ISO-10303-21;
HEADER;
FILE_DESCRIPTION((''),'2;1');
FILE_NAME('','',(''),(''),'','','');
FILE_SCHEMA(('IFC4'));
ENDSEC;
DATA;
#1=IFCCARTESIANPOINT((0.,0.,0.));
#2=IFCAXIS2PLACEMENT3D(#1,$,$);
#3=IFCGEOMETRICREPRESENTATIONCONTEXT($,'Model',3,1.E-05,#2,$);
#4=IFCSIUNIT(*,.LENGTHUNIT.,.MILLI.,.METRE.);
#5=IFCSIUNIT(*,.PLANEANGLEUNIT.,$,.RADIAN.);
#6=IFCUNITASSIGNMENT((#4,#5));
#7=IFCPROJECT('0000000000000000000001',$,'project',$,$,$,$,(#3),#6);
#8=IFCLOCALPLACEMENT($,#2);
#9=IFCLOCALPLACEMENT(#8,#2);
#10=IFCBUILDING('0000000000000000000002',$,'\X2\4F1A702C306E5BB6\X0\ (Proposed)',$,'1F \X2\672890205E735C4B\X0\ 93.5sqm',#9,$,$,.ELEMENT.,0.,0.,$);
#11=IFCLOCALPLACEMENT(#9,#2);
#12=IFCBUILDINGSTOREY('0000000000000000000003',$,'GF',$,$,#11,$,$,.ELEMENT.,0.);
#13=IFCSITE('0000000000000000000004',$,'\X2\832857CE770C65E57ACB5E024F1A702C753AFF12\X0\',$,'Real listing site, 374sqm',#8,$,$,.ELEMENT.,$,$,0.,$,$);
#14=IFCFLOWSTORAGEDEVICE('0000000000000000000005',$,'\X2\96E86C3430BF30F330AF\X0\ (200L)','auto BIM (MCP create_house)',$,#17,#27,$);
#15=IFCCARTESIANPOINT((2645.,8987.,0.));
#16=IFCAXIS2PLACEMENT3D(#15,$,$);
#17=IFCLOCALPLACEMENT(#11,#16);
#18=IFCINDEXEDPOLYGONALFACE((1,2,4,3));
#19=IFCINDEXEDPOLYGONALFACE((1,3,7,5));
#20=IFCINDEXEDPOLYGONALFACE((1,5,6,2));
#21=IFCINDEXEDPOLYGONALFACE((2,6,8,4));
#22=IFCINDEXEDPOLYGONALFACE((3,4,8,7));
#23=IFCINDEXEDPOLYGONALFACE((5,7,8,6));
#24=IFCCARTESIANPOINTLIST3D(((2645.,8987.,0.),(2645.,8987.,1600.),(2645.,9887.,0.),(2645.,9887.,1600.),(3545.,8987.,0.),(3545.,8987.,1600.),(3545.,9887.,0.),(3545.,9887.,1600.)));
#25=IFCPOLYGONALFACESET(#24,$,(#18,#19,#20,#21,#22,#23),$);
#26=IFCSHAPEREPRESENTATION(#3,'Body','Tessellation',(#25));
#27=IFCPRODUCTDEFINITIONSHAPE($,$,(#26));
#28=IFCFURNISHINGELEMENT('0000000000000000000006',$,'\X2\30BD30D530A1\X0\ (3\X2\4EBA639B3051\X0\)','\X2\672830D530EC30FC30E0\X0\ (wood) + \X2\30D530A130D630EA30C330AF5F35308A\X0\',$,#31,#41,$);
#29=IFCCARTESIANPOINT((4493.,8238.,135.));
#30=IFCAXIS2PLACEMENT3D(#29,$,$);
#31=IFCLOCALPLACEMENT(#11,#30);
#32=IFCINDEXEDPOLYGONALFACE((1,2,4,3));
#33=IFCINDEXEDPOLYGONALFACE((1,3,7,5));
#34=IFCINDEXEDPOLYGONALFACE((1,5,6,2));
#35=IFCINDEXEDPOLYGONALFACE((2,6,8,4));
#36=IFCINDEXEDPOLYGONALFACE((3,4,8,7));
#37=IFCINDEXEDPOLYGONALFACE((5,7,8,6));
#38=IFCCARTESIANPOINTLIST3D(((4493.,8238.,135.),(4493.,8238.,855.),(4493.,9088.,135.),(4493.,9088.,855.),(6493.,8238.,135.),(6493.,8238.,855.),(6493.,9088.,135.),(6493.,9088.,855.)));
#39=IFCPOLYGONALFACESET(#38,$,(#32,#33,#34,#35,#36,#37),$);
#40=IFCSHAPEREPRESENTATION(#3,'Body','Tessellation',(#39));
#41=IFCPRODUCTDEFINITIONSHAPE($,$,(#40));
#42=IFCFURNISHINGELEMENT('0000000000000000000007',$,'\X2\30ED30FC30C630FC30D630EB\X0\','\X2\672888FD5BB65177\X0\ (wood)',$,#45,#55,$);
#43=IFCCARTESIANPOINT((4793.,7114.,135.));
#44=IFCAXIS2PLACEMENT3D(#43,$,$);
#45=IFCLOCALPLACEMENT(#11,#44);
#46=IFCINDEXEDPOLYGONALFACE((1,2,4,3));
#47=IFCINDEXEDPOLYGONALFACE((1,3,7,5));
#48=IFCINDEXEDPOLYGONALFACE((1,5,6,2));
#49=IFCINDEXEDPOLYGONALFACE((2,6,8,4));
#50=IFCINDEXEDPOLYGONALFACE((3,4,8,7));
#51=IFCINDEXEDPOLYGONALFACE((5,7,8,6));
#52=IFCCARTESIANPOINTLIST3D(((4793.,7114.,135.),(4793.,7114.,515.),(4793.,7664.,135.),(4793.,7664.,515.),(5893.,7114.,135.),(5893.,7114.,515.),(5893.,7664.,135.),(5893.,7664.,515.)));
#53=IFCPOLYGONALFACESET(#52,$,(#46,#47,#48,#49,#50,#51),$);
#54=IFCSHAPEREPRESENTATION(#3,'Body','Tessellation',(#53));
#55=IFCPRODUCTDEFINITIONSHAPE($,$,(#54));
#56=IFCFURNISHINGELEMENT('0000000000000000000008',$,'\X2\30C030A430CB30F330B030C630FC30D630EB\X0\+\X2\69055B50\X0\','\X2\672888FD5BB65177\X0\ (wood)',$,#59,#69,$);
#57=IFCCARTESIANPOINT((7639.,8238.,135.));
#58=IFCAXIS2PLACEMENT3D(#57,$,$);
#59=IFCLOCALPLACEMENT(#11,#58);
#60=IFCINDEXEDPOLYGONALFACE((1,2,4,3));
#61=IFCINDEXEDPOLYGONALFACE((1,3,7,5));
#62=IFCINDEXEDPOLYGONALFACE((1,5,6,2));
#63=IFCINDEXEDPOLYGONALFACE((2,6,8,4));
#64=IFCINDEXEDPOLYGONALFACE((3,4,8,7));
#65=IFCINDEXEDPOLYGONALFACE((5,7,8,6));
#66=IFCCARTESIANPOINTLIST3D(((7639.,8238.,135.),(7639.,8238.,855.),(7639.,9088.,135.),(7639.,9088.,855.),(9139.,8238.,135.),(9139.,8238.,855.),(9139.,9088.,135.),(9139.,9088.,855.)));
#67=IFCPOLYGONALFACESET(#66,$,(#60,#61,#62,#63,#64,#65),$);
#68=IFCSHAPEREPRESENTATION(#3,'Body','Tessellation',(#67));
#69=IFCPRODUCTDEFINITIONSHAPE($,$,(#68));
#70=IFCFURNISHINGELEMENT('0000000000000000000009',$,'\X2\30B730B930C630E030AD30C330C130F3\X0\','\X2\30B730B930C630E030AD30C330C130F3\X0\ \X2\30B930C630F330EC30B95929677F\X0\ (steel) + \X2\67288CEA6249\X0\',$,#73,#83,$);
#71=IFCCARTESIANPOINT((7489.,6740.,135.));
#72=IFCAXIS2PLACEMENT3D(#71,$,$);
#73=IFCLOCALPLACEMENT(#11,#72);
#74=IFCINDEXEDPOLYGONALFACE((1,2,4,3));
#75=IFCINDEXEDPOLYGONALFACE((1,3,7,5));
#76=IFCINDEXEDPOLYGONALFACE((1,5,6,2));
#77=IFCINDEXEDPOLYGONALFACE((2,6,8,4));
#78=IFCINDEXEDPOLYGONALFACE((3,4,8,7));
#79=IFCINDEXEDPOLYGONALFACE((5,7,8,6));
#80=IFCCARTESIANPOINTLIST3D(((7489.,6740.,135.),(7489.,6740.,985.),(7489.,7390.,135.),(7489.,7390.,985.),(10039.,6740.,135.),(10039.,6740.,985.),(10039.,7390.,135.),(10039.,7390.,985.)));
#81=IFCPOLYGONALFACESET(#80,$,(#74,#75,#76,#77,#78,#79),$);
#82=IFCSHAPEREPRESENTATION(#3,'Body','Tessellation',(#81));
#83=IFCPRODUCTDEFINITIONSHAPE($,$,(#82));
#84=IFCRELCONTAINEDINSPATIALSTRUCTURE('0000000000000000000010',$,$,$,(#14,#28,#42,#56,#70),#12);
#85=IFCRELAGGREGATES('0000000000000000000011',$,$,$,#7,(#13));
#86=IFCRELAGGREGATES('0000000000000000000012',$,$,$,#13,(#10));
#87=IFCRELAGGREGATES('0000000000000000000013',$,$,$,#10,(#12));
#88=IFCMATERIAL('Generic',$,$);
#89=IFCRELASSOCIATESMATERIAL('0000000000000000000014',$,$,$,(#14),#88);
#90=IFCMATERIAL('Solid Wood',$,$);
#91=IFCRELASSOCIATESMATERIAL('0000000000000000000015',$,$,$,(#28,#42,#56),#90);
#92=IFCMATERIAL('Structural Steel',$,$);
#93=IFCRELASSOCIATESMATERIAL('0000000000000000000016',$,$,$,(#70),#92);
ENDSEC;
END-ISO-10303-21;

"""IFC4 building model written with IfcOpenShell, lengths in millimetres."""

from ifc_helpers import new_model, si_unit, frame, frame_2d, origin, place, context, project, spatial, rectangle, extrude, material, element, save


model = new_model("IFC4")

# Units and contexts
model_context = context("Model", 3, precision=1e-05, world=origin())
ifc_project = project(units=[si_unit("LENGTHUNIT", "METRE", prefix="MILLI"), si_unit("PLANEANGLEUNIT", "RADIAN")], contexts=[model_context])

# Site, building, storey
site_placement = place(None, origin())
site = spatial("IfcSite", under=ifc_project, at=site_placement, Name="茨城県日立市会瀬町２", ObjectType="Real listing site, 374sqm", CompositionType="ELEMENT", RefElevation=0.0)
building_placement = place(site_placement, origin())
building = spatial("IfcBuilding", under=site, at=building_placement, Name="会瀬の家 (Proposed)", ObjectType="1F 木造平屋 93.5sqm", CompositionType="ELEMENT", ElevationOfRefHeight=0.0, ElevationOfTerrain=0.0)
storey_placement = place(building_placement, origin())
storey = spatial("IfcBuildingStorey", under=building, at=storey_placement, Name="GF", CompositionType="ELEMENT", Elevation=0.0)

# Shared definitions
ifc_material_1 = material(Name="Solid Wood")

# Shared definitions
ifc_material_2 = material(Name="Structural Steel")

# Shared definitions
ifc_material_3 = material(Name="Generic")

# Flow storage device
flow_storage_device_placement = place(storey_placement, frame((2645.0, 8987.0, 0.0)))
element("IfcFlowStorageDevice", 1, at=flow_storage_device_placement, inside=storey, material=ifc_material_3, Name="雨水タンク (200L)", Description="auto BIM (MCP create_house)", context=model_context, shape_type="SweptSolid", body=[
    extrude(rectangle(XDim=900.0, YDim=900.0, at=frame_2d((450.0, 450.0))), frame((2645.0, 8987.0, 0.0)), (0.0, 0.0, 1.0), 1600.0),
])

# Furnishing elements
furnishing_1_placement = place(storey_placement, frame((4493.0, 8238.0, 135.0)))
element("IfcFurnishingElement", 2, at=furnishing_1_placement, inside=storey, material=ifc_material_1, Name="ソファ (3人掛け)", Description="木フレーム (wood) + ファブリック張り", context=model_context, shape_type="SweptSolid", body=[
    extrude(rectangle(XDim=2000.0, YDim=850.0, at=frame_2d((1000.0, 425.0))), frame((4493.0, 8238.0, 135.0)), (0.0, 0.0, 1.0), 720.0),
])
furnishing_2_placement = place(storey_placement, frame((4793.0, 7114.0, 135.0)))
element("IfcFurnishingElement", 3, at=furnishing_2_placement, inside=storey, material=ifc_material_1, Name="ローテーブル", Description="木製家具 (wood)", context=model_context, shape_type="SweptSolid", body=[
    extrude(rectangle(XDim=1100.0, YDim=550.0, at=frame_2d((550.0, 275.0))), frame((4793.0, 7114.0, 135.0)), (0.0, 0.0, 1.0), 380.0),
])
furnishing_3_placement = place(storey_placement, frame((7639.0, 8238.0, 135.0)))
element("IfcFurnishingElement", 4, at=furnishing_3_placement, inside=storey, material=ifc_material_1, Name="ダイニングテーブル+椅子", Description="木製家具 (wood)", context=model_context, shape_type="SweptSolid", body=[
    extrude(rectangle(XDim=1500.0, YDim=850.0, at=frame_2d((750.0, 425.0))), frame((7639.0, 8238.0, 135.0)), (0.0, 0.0, 1.0), 720.0),
])
furnishing_4_placement = place(storey_placement, frame((7489.0, 6740.0, 135.0)))
element("IfcFurnishingElement", 5, at=furnishing_4_placement, inside=storey, material=ifc_material_2, Name="システムキッチン", Description="システムキッチン ステンレス天板 (steel) + 木質扉", context=model_context, shape_type="SweptSolid", body=[
    extrude(rectangle(XDim=2550.0, YDim=650.0, at=frame_2d((1275.0, 325.0))), frame((7489.0, 6740.0, 135.0)), (0.0, 0.0, 1.0), 850.0),
])

save(model, "model.ifc")
